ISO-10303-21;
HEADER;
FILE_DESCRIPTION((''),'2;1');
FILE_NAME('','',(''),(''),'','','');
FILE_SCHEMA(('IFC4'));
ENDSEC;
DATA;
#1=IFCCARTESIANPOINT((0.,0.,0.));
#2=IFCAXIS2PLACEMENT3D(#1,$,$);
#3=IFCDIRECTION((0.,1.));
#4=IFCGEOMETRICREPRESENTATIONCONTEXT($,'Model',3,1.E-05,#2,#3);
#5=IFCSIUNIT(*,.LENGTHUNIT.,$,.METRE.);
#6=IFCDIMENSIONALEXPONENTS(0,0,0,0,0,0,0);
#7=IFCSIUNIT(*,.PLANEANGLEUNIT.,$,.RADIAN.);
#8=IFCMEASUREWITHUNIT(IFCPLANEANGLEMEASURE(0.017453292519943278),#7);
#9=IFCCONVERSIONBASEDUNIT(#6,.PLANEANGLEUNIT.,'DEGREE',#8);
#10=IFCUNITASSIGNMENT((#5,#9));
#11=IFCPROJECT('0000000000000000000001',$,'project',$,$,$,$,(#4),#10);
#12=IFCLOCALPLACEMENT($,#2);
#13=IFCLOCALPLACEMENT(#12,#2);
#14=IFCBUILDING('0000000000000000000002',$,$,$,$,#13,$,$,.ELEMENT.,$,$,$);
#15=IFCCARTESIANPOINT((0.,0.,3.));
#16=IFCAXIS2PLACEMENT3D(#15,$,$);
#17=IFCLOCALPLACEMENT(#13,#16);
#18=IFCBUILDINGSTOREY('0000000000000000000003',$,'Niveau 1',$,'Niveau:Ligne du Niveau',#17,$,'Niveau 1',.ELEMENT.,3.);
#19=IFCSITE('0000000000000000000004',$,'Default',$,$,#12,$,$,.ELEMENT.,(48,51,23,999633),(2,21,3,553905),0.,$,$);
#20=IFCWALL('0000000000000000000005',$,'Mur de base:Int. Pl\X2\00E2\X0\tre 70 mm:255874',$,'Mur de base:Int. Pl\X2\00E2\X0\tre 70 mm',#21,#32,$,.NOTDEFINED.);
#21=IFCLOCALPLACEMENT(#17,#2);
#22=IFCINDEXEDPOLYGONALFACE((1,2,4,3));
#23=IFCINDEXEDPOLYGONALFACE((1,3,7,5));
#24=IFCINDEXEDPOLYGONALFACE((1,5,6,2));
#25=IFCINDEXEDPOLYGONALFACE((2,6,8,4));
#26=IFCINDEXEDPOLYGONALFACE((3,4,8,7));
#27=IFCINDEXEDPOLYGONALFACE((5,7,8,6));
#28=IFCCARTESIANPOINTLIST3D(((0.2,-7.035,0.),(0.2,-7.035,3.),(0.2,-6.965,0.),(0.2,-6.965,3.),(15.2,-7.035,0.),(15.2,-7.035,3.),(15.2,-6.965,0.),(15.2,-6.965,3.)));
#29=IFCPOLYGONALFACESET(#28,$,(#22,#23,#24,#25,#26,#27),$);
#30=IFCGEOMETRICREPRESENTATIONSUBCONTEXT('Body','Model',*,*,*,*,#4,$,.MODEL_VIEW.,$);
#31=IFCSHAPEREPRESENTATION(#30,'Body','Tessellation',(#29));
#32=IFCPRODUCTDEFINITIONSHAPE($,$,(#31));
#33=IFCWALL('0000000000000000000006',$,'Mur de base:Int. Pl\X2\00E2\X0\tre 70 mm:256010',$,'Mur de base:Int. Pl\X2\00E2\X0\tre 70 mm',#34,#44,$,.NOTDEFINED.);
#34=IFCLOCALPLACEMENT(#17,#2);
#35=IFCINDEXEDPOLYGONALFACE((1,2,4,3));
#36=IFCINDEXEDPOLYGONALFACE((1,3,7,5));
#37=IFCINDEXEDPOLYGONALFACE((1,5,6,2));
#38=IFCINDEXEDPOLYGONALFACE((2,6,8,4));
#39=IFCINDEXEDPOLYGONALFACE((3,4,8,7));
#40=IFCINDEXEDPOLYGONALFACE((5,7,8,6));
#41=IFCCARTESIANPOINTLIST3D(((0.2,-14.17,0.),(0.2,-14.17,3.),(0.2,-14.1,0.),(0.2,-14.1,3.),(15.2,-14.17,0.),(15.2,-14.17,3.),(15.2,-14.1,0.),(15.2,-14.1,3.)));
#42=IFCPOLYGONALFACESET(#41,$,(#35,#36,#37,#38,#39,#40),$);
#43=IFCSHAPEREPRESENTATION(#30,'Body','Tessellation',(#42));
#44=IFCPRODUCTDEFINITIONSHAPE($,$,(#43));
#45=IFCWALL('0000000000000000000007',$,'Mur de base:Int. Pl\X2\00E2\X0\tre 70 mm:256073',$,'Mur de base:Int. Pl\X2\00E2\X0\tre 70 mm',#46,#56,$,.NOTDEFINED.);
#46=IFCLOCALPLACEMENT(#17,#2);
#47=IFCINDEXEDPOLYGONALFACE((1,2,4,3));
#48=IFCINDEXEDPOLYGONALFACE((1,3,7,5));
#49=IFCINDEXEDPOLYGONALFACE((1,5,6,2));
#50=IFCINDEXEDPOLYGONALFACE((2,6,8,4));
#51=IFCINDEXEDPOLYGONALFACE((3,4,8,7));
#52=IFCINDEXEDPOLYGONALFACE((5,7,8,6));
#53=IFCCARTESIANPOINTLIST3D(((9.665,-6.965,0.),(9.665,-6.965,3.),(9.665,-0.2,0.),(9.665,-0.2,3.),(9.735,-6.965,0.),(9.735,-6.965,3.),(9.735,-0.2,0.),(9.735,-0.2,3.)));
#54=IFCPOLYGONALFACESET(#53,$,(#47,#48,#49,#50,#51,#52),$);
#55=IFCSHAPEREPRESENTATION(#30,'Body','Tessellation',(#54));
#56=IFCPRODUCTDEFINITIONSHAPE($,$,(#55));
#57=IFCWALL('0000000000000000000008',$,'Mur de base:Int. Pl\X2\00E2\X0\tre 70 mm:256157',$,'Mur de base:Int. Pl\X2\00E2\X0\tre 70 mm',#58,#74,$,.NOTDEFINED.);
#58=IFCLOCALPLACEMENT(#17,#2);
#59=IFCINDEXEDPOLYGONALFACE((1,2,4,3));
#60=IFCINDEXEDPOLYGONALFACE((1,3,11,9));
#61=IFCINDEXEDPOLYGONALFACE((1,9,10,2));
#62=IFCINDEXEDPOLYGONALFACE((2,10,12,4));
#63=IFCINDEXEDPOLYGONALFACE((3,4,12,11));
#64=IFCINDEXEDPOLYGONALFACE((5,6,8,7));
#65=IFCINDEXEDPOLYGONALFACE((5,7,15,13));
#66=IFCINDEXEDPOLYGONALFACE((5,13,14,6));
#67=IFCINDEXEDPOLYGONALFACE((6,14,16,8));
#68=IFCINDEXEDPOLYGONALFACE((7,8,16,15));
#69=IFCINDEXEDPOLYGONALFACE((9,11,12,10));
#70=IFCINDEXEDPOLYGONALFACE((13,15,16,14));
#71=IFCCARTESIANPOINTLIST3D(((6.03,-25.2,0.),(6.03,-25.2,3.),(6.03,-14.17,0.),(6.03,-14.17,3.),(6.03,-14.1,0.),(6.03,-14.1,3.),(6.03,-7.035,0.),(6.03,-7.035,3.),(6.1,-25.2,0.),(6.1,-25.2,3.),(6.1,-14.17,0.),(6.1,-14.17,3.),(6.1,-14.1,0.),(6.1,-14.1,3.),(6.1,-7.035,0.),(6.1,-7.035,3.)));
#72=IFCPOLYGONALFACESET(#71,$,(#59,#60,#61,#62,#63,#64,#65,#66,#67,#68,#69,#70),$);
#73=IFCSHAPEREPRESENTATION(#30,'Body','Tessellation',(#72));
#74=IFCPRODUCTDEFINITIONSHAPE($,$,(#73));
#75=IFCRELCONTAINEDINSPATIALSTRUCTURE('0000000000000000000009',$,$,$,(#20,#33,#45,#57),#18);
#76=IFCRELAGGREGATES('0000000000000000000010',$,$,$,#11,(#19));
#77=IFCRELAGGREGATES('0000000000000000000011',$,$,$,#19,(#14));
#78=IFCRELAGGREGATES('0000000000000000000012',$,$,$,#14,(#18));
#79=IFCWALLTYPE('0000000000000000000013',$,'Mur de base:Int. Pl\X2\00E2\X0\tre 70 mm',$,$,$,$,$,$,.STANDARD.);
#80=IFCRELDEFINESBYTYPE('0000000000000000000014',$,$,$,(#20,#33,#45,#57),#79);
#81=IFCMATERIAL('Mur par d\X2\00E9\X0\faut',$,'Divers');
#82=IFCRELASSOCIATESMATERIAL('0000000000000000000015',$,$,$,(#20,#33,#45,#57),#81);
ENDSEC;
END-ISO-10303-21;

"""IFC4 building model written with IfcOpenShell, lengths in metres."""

from ifc_helpers import new_model, entity, si_unit, converted_unit, direction, frame, origin, place, context, subcontext, project, spatial, indexed_curve, outline, extrude, material, type_object, element, save


model = new_model("IFC4")

# Units and contexts
model_context = context("Model", 3, precision=1e-05, world=origin(), true_north=direction((0.0, 1.0)))
body_context = subcontext(model_context, "Body", "Model", "MODEL_VIEW")
ifc_project = project(units=[si_unit("LENGTHUNIT", "METRE"), converted_unit("PLANEANGLEUNIT", "DEGREE", entity("IfcPlaneAngleMeasure", 0.017453292519943278), si_unit("PLANEANGLEUNIT", "RADIAN"), dimensions=[0, 0, 0, 0, 0, 0, 0])], contexts=[model_context])

# Site, building, storey
site_placement = place(None, origin())
site = spatial("IfcSite", under=ifc_project, at=site_placement, Name="Default", CompositionType="ELEMENT", RefLatitude=(48, 51, 23, 999633), RefLongitude=(2, 21, 3, 553905), RefElevation=0.0)
building_placement = place(site_placement, origin())
building = spatial("IfcBuilding", under=site, at=building_placement, CompositionType="ELEMENT")
storey_placement = place(building_placement, frame((0.0, 0.0, 3.0)))
storey = spatial("IfcBuildingStorey", under=building, at=storey_placement, Name="Niveau 1", ObjectType="Niveau:Ligne du Niveau", LongName="Niveau 1", CompositionType="ELEMENT", Elevation=3.0)

# Walls
ifc_material_1 = material(Name="Mur par défaut", Category="Divers")
wall_type = type_object("IfcWallType", Name="Mur de base:Int. Plâtre 70 mm", PredefinedType="STANDARD")
wall_1_placement = place(storey_placement, frame((0.2, -7.0, 0.0)))
element("IfcWall", 1, at=wall_1_placement, inside=storey, type_object=wall_type, material=ifc_material_1, Name="Mur de base:Int. Plâtre 70 mm:255874", ObjectType="Mur de base:Int. Plâtre 70 mm", PredefinedType="NOTDEFINED", context=body_context, shape_type="SweptSolid", body=[
    extrude(outline(indexed_curve([(15.0, 0.035), (0.0, 0.035), (0.0, -0.035), (15.0, -0.035), (15.0, 0.035)], self_intersect=False)), origin(), (0.0, 0.0, 1.0), 3.0),
])
wall_2_placement = place(storey_placement, frame((0.2, -14.135, 0.0)))
element("IfcWall", 2, at=wall_2_placement, inside=storey, type_object=wall_type, material=ifc_material_1, Name="Mur de base:Int. Plâtre 70 mm:256010", ObjectType="Mur de base:Int. Plâtre 70 mm", PredefinedType="NOTDEFINED", context=body_context, shape_type="SweptSolid", body=[
    extrude(outline(indexed_curve([(15.0, 0.035), (0.0, 0.035), (0.0, -0.035), (15.0, -0.035), (15.0, 0.035)], self_intersect=False)), origin(), (0.0, 0.0, 1.0), 3.0),
])
wall_3_placement = place(storey_placement, frame((9.7, -0.2, 0.0), z_axis=(0.0, 0.0, 1.0), x_axis=(0.0, -1.0, 0.0)))
element("IfcWall", 3, at=wall_3_placement, inside=storey, type_object=wall_type, material=ifc_material_1, Name="Mur de base:Int. Plâtre 70 mm:256073", ObjectType="Mur de base:Int. Plâtre 70 mm", PredefinedType="NOTDEFINED", context=body_context, shape_type="SweptSolid", body=[
    extrude(outline(indexed_curve([(6.765, 0.035), (0.0, 0.035), (0.0, -0.035), (6.765, -0.035), (6.765, 0.035)], self_intersect=False)), origin(), (0.0, 0.0, 1.0), 3.0),
])

# Wall, opening
wall_4_placement = place(storey_placement, frame((6.065, -7.035, 0.0), z_axis=(0.0, 0.0, 1.0), x_axis=(0.0, -1.0, 0.0)))
wall_4 = element("IfcWall", 4, at=wall_4_placement, inside=storey, type_object=wall_type, material=ifc_material_1, Name="Mur de base:Int. Plâtre 70 mm:256157", ObjectType="Mur de base:Int. Plâtre 70 mm", PredefinedType="NOTDEFINED", context=body_context, shape_type="SweptSolid", body=[
    extrude(outline(indexed_curve([(18.165, 0.035), (0.0, 0.035), (0.0, -0.035), (18.165, -0.035), (18.165, 0.035)], self_intersect=False)), origin(), (0.0, 0.0, 1.0), 3.0),
])
opening_placement = place(storey_placement, frame((6.065, -7.035, 0.0), z_axis=(0.0, 0.0, 1.0), x_axis=(0.0, -1.0, 0.0)))
element("IfcOpeningElement", 5, at=opening_placement, cuts=wall_4, PredefinedType="OPENING", context=body_context, shape_type="SweptSolid", body=[
    extrude(outline(indexed_curve([(-1.5, -0.035), (1.5, -0.035), (1.5, 0.035), (-1.5, 0.035), (-1.5, -0.035)], self_intersect=False)), frame((7.135, 0.0, 1.5), z_axis=(-1.0, 0.0, 0.0), x_axis=(0.0, 0.0, 1.0)), (0.0, 0.0, 1.0), 0.07),
])

save(model, "model.ifc")
